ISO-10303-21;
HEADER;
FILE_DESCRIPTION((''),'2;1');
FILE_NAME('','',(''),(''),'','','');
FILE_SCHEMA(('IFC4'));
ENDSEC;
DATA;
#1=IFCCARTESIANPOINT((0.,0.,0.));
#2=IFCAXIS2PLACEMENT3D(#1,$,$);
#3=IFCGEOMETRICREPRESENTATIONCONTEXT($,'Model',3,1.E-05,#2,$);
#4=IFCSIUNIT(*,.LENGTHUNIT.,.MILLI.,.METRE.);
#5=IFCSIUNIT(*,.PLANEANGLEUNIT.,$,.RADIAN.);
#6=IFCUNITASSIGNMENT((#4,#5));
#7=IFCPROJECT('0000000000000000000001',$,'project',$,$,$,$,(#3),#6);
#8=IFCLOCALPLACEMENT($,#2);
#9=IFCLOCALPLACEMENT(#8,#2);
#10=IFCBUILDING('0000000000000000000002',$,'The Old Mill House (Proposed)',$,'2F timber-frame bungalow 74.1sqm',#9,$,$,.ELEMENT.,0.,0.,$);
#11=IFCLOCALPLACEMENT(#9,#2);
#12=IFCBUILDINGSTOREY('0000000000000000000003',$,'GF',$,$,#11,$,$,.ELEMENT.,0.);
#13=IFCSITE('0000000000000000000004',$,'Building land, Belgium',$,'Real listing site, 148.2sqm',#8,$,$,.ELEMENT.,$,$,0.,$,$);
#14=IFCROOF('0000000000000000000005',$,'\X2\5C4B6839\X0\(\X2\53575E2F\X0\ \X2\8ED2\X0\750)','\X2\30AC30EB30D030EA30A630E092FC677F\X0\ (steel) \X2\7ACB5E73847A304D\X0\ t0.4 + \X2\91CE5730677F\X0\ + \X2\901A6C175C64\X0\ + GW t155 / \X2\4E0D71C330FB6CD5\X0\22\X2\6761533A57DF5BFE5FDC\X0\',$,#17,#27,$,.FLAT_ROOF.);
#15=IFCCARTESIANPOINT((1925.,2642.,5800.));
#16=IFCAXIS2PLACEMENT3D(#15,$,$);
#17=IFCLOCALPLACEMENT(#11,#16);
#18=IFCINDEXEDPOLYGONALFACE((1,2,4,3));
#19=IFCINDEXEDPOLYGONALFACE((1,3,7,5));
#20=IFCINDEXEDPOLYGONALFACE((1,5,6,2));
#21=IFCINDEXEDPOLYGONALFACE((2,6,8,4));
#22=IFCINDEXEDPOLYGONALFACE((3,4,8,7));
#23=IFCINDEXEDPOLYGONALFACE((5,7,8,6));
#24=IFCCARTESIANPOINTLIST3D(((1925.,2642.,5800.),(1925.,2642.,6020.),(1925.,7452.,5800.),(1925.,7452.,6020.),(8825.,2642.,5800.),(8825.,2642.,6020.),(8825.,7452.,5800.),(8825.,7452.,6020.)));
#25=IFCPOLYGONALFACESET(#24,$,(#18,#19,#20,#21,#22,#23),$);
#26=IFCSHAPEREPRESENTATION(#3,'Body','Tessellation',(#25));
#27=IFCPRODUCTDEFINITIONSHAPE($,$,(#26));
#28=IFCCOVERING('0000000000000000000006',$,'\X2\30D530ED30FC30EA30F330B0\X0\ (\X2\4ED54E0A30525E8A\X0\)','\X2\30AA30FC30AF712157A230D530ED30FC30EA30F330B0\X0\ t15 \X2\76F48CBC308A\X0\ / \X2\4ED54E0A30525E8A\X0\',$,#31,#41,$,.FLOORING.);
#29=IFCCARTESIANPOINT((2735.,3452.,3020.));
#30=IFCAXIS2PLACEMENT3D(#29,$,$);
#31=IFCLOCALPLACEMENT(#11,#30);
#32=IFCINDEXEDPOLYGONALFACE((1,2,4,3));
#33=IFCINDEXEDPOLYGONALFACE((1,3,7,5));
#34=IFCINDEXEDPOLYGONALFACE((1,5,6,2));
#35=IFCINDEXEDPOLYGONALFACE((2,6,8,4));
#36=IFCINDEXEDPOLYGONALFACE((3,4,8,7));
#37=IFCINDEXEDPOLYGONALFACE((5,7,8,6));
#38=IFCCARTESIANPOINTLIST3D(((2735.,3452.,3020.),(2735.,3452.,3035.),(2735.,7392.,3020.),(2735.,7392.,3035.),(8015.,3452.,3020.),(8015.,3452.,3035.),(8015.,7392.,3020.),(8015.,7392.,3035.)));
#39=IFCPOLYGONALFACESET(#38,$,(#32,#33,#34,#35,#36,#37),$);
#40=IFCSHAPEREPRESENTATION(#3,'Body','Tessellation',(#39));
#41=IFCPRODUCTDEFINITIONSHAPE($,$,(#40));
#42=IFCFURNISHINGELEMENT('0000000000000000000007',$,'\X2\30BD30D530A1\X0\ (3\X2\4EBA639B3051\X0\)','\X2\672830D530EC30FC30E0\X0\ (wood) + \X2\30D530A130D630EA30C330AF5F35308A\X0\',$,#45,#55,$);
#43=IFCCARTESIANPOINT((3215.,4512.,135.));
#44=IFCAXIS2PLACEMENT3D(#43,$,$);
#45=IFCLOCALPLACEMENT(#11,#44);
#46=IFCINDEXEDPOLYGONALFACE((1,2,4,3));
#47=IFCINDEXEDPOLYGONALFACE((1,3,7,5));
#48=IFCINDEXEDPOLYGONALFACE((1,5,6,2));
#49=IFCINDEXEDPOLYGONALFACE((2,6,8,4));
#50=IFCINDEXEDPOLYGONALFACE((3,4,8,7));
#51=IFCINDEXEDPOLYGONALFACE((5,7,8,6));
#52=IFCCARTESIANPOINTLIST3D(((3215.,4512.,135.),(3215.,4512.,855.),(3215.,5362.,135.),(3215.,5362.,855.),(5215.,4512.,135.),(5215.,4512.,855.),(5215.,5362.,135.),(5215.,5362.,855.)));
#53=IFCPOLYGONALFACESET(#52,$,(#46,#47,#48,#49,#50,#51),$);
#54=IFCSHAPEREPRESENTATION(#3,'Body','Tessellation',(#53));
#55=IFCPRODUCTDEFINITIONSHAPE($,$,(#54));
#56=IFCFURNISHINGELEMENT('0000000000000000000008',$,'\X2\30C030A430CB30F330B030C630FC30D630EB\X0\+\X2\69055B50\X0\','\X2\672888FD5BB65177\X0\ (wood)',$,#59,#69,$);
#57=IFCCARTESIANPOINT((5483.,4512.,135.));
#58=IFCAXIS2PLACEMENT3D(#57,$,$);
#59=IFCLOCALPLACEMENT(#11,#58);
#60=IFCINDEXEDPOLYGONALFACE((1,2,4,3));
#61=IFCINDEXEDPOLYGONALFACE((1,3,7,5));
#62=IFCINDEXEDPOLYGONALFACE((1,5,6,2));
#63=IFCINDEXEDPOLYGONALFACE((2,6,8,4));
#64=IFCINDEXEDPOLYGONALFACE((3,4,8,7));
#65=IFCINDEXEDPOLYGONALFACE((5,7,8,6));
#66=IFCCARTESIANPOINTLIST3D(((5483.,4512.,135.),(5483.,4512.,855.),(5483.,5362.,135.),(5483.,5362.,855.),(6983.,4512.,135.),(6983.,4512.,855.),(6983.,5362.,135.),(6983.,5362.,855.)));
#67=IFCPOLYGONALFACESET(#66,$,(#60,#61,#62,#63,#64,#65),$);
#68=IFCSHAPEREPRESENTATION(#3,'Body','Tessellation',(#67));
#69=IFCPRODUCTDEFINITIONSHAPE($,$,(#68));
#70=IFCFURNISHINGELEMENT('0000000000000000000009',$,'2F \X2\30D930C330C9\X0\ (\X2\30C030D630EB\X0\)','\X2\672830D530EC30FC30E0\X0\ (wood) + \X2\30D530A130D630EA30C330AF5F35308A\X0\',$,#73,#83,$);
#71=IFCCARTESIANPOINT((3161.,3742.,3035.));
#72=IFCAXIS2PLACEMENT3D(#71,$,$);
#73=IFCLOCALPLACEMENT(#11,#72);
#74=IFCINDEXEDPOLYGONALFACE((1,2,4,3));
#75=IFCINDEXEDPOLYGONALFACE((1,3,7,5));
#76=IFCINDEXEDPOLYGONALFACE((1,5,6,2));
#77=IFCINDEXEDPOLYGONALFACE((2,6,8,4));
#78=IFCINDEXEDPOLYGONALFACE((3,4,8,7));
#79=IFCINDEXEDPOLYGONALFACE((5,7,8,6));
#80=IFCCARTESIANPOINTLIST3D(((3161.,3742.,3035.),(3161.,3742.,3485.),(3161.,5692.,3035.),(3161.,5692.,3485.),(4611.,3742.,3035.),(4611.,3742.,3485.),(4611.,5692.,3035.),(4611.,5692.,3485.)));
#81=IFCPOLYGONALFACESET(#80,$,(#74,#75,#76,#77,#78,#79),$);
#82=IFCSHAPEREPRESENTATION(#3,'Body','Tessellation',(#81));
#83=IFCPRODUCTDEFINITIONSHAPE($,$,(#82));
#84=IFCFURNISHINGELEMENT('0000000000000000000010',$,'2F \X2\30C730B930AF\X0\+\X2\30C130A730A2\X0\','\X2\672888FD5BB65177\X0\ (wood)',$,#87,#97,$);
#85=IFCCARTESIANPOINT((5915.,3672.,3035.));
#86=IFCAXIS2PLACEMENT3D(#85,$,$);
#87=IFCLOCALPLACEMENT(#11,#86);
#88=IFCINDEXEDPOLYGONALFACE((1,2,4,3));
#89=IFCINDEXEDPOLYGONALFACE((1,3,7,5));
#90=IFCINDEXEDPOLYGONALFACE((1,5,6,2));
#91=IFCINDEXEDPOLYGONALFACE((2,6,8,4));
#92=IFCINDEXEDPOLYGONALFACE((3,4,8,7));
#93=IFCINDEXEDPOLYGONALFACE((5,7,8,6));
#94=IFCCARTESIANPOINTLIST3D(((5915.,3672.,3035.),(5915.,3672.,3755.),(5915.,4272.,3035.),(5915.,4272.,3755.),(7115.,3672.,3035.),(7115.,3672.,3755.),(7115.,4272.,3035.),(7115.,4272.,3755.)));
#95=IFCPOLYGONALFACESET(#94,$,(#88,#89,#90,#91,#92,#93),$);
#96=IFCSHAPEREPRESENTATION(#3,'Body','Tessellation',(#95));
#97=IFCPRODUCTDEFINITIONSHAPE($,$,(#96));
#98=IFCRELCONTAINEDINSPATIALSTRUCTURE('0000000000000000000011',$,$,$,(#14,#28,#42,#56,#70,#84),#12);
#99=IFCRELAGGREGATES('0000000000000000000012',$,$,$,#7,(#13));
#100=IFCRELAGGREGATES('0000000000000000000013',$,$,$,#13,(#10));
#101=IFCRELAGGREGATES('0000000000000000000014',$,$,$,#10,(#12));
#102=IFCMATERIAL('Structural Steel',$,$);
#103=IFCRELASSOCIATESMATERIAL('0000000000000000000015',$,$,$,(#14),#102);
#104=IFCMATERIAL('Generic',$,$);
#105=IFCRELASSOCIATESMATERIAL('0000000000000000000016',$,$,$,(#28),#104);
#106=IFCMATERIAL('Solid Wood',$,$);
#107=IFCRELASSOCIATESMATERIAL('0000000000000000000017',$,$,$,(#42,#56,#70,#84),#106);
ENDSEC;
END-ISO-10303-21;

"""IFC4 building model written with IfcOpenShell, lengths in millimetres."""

from ifc_helpers import new_model, si_unit, frame, frame_2d, origin, place, context, project, spatial, rectangle, extrude, material, element, save


model = new_model("IFC4")

# Units and contexts
model_context = context("Model", 3, precision=1e-05, world=origin())
ifc_project = project(units=[si_unit("LENGTHUNIT", "METRE", prefix="MILLI"), si_unit("PLANEANGLEUNIT", "RADIAN")], contexts=[model_context])

# Site, building, storey
site_placement = place(None, origin())
site = spatial("IfcSite", under=ifc_project, at=site_placement, Name="Building land, Belgium", ObjectType="Real listing site, 148.2sqm", CompositionType="ELEMENT", RefElevation=0.0)
building_placement = place(site_placement, origin())
building = spatial("IfcBuilding", under=site, at=building_placement, Name="The Old Mill House (Proposed)", ObjectType="2F timber-frame bungalow 74.1sqm", CompositionType="ELEMENT", ElevationOfRefHeight=0.0, ElevationOfTerrain=0.0)
storey_placement = place(building_placement, origin())
storey = spatial("IfcBuildingStorey", under=building, at=storey_placement, Name="GF", CompositionType="ELEMENT", Elevation=0.0)

# Shared definitions
ifc_material_1 = material(Name="Solid Wood")

# Roof
ifc_material_2 = material(Name="Structural Steel")
for number, where, name in (
    (1, (1925.0, 2642.0, 5800.0), "屋根(南帯 軒750)"),
):
    element("IfcRoof", number, at=place(storey_placement, frame(where)), inside=storey, material=ifc_material_2, Name=name, Description="ガルバリウム鋼板 (steel) 立平葺き t0.4 + 野地板 + 通気層 + GW t155 / 不燃・法22条区域対応", PredefinedType="FLAT_ROOF", context=model_context, shape_type="SweptSolid", body=[
        extrude(rectangle(XDim=6900.0, YDim=4810.0, at=frame_2d((3450.0, 2405.0))), frame((1925.0, 2642.0, 5800.0)), (0.0, 0.0, 1.0), 220.0),
    ])

# Covering
ifc_material_3 = material(Name="Generic")
covering_placement = place(storey_placement, frame((2735.0, 3452.0, 3020.0)))
element("IfcCovering", 2, at=covering_placement, inside=storey, material=ifc_material_3, Name="フローリング (仕上げ床)", Description="オーク無垢フローリング t15 直貼り / 仕上げ床", PredefinedType="FLOORING", context=model_context, shape_type="SweptSolid", body=[
    extrude(rectangle(XDim=5280.0, YDim=3940.0, at=frame_2d((2640.0, 1970.0))), frame((2735.0, 3452.0, 3020.0)), (0.0, 0.0, 1.0), 15.0),
])

# Furnishing elements
furnishing_1_placement = place(storey_placement, frame((3215.0, 4512.0, 135.0)))
element("IfcFurnishingElement", 3, at=furnishing_1_placement, inside=storey, material=ifc_material_1, Name="ソファ (3人掛け)", Description="木フレーム (wood) + ファブリック張り", context=model_context, shape_type="SweptSolid", body=[
    extrude(rectangle(XDim=2000.0, YDim=850.0, at=frame_2d((1000.0, 425.0))), frame((3215.0, 4512.0, 135.0)), (0.0, 0.0, 1.0), 720.0),
])
furnishing_2_placement = place(storey_placement, frame((5483.0, 4512.0, 135.0)))
element("IfcFurnishingElement", 4, at=furnishing_2_placement, inside=storey, material=ifc_material_1, Name="ダイニングテーブル+椅子", Description="木製家具 (wood)", context=model_context, shape_type="SweptSolid", body=[
    extrude(rectangle(XDim=1500.0, YDim=850.0, at=frame_2d((750.0, 425.0))), frame((5483.0, 4512.0, 135.0)), (0.0, 0.0, 1.0), 720.0),
])
furnishing_3_placement = place(storey_placement, frame((3161.0, 3742.0, 3035.0)))
element("IfcFurnishingElement", 5, at=furnishing_3_placement, inside=storey, material=ifc_material_1, Name="2F ベッド (ダブル)", Description="木フレーム (wood) + ファブリック張り", context=model_context, shape_type="SweptSolid", body=[
    extrude(rectangle(XDim=1450.0, YDim=1950.0, at=frame_2d((725.0, 975.0))), frame((3161.0, 3742.0, 3035.0)), (0.0, 0.0, 1.0), 450.0),
])
furnishing_4_placement = place(storey_placement, frame((5915.0, 3672.0, 3035.0)))
element("IfcFurnishingElement", 6, at=furnishing_4_placement, inside=storey, material=ifc_material_1, Name="2F デスク+チェア", Description="木製家具 (wood)", context=model_context, shape_type="SweptSolid", body=[
    extrude(rectangle(XDim=1200.0, YDim=600.0, at=frame_2d((600.0, 300.0))), frame((5915.0, 3672.0, 3035.0)), (0.0, 0.0, 1.0), 720.0),
])

save(model, "model.ifc")
